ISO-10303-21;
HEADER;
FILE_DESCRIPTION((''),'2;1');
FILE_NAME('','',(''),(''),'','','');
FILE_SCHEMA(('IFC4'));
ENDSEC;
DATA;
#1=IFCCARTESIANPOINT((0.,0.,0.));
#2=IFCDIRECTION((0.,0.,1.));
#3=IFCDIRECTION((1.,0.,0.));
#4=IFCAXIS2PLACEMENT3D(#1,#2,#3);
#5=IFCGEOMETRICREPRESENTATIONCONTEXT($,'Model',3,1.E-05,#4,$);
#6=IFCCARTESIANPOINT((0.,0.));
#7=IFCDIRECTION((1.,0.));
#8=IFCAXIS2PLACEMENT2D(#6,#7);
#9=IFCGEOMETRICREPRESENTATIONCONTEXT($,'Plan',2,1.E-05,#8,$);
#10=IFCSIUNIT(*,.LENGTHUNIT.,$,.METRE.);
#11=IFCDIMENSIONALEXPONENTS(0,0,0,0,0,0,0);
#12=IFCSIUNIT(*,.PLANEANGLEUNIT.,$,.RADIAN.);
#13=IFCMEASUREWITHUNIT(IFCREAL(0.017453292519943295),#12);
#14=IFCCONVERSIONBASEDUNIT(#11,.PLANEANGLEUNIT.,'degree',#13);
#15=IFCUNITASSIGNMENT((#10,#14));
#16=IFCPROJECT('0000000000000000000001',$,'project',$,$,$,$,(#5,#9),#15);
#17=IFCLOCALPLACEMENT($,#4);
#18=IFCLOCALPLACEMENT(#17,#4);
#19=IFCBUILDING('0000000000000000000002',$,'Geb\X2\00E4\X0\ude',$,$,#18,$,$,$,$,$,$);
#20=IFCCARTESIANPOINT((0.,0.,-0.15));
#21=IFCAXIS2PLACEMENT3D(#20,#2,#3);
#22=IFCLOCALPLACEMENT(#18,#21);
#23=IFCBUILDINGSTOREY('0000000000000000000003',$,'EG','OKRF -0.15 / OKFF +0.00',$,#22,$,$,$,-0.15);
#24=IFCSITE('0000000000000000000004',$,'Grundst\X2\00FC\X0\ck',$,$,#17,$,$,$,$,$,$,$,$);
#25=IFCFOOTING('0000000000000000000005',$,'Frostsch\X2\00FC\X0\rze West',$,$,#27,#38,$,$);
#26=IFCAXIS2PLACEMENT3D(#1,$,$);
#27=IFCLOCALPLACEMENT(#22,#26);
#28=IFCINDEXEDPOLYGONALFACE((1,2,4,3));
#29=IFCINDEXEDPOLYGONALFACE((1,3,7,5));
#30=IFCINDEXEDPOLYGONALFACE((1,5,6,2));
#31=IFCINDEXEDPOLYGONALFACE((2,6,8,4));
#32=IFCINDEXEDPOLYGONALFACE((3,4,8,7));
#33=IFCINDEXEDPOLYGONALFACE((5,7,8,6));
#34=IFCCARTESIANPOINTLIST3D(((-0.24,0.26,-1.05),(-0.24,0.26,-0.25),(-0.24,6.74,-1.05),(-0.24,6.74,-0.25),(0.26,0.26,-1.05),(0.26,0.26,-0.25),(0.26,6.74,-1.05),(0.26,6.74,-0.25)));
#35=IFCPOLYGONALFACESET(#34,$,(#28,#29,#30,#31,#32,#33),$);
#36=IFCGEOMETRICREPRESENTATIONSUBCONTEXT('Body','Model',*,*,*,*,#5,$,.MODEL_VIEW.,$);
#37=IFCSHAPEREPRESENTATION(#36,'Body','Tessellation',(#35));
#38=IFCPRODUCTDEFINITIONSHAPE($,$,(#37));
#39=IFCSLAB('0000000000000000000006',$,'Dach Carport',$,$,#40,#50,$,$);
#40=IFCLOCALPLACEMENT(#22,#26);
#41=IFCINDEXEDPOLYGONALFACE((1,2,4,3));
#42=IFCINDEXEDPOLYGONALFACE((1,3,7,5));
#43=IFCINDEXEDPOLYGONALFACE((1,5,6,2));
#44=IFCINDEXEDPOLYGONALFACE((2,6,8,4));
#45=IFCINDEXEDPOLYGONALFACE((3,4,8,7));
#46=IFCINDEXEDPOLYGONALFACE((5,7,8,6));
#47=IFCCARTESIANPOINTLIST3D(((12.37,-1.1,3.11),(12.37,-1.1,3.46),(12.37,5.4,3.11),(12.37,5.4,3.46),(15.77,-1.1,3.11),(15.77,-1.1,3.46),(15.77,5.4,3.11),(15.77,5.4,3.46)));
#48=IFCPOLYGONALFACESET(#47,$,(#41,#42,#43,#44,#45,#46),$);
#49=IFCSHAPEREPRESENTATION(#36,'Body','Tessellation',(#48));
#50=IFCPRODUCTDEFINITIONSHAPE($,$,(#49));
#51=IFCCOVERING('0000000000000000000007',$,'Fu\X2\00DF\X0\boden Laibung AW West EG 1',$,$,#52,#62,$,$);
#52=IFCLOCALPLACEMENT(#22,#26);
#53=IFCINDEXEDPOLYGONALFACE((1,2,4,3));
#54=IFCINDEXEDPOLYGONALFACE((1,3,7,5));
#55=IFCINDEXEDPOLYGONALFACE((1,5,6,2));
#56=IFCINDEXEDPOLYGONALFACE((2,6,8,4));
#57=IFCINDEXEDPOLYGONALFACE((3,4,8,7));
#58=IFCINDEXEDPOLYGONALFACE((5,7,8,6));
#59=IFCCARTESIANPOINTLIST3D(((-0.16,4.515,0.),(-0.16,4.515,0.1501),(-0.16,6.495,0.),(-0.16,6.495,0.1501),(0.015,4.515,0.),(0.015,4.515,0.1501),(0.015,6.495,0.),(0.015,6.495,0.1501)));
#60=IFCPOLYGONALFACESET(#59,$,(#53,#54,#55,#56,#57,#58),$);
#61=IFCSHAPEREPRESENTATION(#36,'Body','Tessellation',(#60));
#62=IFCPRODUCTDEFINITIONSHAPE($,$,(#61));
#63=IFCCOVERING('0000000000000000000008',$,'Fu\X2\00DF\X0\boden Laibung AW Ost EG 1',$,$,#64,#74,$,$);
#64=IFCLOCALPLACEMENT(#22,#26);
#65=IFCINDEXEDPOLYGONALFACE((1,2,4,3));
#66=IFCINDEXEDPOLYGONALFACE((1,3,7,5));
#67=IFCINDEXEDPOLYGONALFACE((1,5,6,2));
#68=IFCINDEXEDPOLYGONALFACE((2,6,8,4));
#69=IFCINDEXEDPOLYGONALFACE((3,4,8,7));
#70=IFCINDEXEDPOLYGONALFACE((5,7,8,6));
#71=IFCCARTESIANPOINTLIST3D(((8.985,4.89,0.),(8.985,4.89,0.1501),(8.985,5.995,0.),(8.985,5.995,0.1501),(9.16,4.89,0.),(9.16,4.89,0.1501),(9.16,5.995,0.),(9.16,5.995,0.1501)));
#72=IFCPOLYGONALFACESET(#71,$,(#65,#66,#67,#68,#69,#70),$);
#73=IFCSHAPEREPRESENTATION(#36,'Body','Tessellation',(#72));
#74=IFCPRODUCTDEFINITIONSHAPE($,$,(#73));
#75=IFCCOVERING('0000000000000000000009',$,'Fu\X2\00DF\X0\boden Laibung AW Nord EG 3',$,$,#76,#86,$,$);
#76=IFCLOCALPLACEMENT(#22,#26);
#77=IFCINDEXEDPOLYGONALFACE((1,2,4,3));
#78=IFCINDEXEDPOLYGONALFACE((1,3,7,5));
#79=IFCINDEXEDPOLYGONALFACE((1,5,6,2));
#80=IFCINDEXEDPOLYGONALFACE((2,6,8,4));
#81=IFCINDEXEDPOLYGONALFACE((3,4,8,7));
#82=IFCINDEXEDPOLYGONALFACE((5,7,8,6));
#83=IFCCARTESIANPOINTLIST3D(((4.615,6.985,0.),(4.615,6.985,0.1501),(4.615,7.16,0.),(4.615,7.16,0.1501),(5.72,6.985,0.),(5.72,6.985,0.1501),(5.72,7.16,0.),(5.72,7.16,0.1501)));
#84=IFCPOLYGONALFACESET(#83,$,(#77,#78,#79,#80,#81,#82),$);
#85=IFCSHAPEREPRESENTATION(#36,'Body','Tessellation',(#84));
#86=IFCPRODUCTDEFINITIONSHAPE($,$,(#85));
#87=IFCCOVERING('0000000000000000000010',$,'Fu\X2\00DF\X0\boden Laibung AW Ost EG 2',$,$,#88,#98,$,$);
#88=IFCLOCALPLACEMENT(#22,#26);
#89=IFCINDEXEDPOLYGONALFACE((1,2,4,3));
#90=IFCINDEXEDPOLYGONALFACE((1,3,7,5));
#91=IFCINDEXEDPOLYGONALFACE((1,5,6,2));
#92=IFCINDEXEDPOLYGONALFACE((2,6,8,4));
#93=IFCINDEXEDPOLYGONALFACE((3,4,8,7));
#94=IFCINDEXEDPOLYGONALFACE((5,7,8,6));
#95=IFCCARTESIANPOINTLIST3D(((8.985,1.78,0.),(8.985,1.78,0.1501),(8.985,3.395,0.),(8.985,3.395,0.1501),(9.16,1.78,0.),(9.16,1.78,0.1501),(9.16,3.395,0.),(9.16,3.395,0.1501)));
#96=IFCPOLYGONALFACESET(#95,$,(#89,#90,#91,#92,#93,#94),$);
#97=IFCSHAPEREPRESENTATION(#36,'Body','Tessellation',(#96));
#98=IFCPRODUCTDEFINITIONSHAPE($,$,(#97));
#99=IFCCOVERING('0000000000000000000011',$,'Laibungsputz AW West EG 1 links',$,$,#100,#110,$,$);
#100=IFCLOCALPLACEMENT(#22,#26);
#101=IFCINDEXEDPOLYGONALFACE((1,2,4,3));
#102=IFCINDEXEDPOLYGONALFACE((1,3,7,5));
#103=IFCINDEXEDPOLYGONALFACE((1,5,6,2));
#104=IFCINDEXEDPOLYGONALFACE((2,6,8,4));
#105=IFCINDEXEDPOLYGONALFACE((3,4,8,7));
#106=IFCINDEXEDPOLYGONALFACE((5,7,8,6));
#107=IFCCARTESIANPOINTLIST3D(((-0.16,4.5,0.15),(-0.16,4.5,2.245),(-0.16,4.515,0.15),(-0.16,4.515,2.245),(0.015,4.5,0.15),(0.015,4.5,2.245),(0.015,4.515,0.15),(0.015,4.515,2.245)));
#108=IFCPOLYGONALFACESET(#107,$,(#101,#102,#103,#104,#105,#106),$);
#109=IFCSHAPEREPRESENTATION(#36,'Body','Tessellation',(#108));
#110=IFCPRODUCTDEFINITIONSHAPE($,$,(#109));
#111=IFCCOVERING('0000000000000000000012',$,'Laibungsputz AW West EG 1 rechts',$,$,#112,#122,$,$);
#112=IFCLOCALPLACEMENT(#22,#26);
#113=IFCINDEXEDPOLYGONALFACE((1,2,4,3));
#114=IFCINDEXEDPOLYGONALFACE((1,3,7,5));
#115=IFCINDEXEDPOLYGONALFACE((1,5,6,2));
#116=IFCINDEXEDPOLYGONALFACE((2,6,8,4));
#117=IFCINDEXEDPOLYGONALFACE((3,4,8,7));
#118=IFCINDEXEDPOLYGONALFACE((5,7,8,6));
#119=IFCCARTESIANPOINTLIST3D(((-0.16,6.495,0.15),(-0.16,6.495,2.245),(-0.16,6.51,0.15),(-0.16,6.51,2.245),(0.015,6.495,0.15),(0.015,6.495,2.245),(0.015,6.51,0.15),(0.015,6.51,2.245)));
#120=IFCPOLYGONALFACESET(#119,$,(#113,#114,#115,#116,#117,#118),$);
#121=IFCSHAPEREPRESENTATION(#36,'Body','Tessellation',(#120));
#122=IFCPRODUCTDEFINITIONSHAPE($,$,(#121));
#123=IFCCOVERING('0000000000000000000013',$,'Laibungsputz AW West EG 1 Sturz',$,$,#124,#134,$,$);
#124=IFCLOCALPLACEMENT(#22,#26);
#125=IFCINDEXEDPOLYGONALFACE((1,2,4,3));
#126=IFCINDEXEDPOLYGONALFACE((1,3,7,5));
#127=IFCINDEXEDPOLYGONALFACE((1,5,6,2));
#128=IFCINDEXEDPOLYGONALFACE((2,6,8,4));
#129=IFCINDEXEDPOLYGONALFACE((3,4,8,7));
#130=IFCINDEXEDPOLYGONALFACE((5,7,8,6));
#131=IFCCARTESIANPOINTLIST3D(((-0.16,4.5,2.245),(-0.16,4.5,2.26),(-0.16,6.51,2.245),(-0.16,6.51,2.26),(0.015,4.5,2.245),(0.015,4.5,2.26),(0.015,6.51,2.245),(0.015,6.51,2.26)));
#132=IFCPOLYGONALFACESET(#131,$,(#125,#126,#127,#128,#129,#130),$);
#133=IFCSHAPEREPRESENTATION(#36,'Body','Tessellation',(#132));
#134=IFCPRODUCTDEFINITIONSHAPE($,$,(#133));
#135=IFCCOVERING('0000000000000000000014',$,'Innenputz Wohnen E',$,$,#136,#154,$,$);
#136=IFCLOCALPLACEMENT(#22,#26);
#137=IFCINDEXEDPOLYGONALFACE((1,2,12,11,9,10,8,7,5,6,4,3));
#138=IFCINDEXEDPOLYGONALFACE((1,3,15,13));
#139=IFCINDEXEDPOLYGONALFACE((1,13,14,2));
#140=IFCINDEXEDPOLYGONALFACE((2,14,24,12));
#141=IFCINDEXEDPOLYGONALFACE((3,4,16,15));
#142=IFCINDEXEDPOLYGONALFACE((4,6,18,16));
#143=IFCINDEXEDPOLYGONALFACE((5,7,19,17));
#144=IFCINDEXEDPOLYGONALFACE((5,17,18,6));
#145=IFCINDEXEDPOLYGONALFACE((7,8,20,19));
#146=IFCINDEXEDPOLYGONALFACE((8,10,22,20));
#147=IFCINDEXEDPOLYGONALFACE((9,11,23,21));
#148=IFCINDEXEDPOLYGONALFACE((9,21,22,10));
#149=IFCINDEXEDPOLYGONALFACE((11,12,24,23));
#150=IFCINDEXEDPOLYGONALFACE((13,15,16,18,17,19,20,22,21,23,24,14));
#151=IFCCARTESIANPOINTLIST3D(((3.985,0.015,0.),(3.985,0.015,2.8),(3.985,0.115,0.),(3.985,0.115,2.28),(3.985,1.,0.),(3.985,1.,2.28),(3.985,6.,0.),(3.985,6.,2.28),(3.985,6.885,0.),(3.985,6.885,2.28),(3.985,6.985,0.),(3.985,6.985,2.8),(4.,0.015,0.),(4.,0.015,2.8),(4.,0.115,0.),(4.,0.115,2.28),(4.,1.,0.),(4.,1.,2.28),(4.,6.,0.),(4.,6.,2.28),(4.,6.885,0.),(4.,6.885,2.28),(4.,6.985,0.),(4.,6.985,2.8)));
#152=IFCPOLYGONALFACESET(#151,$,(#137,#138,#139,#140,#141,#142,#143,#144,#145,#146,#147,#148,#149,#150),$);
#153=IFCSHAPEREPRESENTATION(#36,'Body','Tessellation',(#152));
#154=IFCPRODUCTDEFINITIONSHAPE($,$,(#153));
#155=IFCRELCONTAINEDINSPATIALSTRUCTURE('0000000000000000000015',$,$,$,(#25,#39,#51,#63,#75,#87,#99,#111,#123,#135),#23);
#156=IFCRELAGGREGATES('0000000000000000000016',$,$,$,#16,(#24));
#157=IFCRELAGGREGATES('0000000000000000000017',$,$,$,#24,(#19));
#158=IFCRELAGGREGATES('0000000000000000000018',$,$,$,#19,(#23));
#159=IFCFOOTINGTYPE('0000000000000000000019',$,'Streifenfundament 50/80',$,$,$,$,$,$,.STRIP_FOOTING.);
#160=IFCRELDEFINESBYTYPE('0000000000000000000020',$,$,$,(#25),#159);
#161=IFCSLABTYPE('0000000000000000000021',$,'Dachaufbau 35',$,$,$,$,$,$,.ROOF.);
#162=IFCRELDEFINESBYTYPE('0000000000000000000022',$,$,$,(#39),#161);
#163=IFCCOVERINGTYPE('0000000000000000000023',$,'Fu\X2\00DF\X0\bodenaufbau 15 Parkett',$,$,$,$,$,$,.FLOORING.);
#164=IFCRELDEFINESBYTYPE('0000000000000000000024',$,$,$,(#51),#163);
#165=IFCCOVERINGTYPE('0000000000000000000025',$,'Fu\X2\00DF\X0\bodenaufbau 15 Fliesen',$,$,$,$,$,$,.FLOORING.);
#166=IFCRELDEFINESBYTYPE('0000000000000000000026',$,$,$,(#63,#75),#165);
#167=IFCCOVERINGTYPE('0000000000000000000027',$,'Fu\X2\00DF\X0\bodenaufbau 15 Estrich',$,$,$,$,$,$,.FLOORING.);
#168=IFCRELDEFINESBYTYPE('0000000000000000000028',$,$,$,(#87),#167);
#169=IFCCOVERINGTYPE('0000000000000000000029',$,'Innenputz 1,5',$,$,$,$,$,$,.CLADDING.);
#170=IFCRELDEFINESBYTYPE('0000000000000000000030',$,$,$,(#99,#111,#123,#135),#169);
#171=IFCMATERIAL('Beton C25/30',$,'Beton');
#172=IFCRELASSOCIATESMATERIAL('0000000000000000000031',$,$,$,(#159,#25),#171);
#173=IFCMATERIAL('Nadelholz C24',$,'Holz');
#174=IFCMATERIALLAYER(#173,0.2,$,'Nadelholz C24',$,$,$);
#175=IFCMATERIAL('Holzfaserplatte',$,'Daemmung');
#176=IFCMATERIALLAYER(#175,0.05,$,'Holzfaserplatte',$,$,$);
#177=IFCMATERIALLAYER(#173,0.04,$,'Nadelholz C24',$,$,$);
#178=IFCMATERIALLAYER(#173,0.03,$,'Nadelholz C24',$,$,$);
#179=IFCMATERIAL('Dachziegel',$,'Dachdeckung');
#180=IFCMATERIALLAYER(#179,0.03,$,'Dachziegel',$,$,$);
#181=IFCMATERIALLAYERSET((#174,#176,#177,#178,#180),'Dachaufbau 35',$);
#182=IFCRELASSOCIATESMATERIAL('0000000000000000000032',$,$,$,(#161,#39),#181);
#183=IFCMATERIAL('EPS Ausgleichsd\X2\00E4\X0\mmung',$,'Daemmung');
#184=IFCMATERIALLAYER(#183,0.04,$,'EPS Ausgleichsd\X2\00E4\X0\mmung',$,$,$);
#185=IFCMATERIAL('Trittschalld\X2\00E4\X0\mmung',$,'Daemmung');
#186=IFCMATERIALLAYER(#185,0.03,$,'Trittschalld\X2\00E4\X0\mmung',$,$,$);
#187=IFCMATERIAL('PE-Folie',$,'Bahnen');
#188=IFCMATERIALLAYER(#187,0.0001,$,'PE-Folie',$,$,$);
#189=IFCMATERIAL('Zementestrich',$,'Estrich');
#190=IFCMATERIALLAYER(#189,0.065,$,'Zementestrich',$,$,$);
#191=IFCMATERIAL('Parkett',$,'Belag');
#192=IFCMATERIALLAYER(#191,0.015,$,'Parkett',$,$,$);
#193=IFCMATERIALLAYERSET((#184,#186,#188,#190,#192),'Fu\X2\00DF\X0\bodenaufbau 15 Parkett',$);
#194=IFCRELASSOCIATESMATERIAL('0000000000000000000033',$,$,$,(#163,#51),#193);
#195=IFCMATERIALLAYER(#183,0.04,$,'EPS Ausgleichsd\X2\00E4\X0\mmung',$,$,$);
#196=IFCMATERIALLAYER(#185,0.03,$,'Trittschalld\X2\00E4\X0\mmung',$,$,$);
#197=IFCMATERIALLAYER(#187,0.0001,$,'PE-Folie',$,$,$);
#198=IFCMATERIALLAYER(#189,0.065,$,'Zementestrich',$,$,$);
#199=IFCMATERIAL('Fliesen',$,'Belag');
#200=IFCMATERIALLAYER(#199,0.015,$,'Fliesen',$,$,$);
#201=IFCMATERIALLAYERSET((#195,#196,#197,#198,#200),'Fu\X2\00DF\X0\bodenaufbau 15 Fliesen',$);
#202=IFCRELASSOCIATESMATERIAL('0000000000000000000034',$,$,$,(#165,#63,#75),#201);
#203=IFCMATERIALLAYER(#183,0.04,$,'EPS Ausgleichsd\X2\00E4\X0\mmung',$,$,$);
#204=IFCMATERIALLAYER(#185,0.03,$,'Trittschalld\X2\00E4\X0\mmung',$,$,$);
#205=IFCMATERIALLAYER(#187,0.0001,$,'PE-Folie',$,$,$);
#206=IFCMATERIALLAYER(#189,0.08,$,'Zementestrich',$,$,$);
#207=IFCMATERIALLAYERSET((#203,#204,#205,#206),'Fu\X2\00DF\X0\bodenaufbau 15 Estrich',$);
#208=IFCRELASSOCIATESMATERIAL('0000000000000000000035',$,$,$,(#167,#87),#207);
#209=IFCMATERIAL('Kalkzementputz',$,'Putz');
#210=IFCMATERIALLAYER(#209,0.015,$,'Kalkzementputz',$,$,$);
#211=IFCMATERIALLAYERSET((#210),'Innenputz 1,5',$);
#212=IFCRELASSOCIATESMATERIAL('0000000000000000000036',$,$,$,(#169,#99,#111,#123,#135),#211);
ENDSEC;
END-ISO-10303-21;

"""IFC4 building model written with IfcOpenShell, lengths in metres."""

from ifc_helpers import new_model, entity, si_unit, converted_unit, frame, origin_with_axes, origin_2d_with_axis, place, context, subcontext, project, spatial, polyline, indexed_curve, rectangle, outline, extrude, material, layer, layer_set, layer_usage, material_profile, profile_set, profile_usage, type_object, element, save


model = new_model("IFC4")

# Units and contexts
model_context = context("Model", 3, precision=1e-05, world=origin_with_axes())
plan_context = context("Plan", 2, precision=1e-05, world=origin_2d_with_axis())
body_context = subcontext(model_context, "Body", "Model", "MODEL_VIEW")
ifc_project = project(units=[si_unit("LENGTHUNIT", "METRE"), converted_unit("PLANEANGLEUNIT", "degree", entity("IfcReal", 0.017453292519943295), si_unit("PLANEANGLEUNIT", "RADIAN"), dimensions=[0, 0, 0, 0, 0, 0, 0])], contexts=[model_context, plan_context])

# Site, building, storey
site_placement = place(None, origin_with_axes())
site = spatial("IfcSite", under=ifc_project, at=site_placement, Name="Grundstück")
building_placement = place(site_placement, origin_with_axes())
building = spatial("IfcBuilding", under=site, at=building_placement, Name="Gebäude")
storey_placement = place(building_placement, frame((0.0, 0.0, -0.15), z_axis=(0.0, 0.0, 1.0), x_axis=(1.0, 0.0, 0.0)))
storey = spatial("IfcBuildingStorey", under=building, at=storey_placement, Name="EG", Description="OKRF -0.15 / OKFF +0.00", Elevation=-0.15)

# Footing
ifc_material_1 = material(Name="Beton C25/30", Category="Beton")
ifc_material_profile = material_profile(ifc_material_1, rectangle(XDim=0.5, YDim=0.8))
ifc_profile_set = profile_set([ifc_material_profile], Name="Streifenfundament 50/80")
ifc_profile_usage = profile_usage(ifc_profile_set)
footing_type = type_object("IfcFootingType", Name="Streifenfundament 50/80", PredefinedType="STRIP_FOOTING", material=ifc_profile_set)
footing_placement = place(storey_placement, frame((0.01, 0.26, -0.65), z_axis=(0.0, 1.0, 0.0), x_axis=(-1.0, 0.0, 0.0)))
element("IfcFooting", 1, at=footing_placement, inside=storey, type_object=footing_type, material=ifc_profile_usage, Name="Frostschürze West", context=body_context, shape_type="SweptSolid", body=[
    extrude(rectangle(XDim=0.5, YDim=0.8), origin_with_axes(), (0.0, 0.0, 1.0), 6.48),
])

# Slab
ifc_material_2 = material(Name="Nadelholz C24", Category="Holz")
ifc_layer_1 = layer(ifc_material_2, 0.2, Name="Nadelholz C24")
ifc_material_3 = material(Name="Holzfaserplatte", Category="Daemmung")
ifc_layer_2 = layer(ifc_material_3, 0.05, Name="Holzfaserplatte")
ifc_layer_3 = layer(ifc_material_2, 0.04, Name="Nadelholz C24")
ifc_layer_4 = layer(ifc_material_2, 0.03, Name="Nadelholz C24")
ifc_material_4 = material(Name="Dachziegel", Category="Dachdeckung")
ifc_layer_5 = layer(ifc_material_4, 0.03, Name="Dachziegel")
ifc_layer_set_1 = layer_set([ifc_layer_1, ifc_layer_2, ifc_layer_3, ifc_layer_4, ifc_layer_5], Name="Dachaufbau 35")
ifc_layer_usage_1 = layer_usage(ifc_layer_set_1, "AXIS3", "POSITIVE", 0.0)
slab_type = type_object("IfcSlabType", Name="Dachaufbau 35", PredefinedType="ROOF", material=ifc_layer_set_1)
slab_placement = place(storey_placement, frame((0.0, 0.0, 3.11), z_axis=(0.0, 0.0, 1.0), x_axis=(1.0, 0.0, 0.0)))
element("IfcSlab", 2, at=slab_placement, inside=storey, type_object=slab_type, material=ifc_layer_usage_1, Name="Dach Carport", context=body_context, shape_type="SweptSolid", body=[
    extrude(outline(indexed_curve([(12.37, -1.1), (15.77, -1.1), (15.77, 5.4), (12.37, 5.4)])), None, (0.0, 0.0, 1.0), 0.35),
])

# Coverings
ifc_material_5 = material(Name="EPS Ausgleichsdämmung", Category="Daemmung")
ifc_layer_6 = layer(ifc_material_5, 0.04, Name="EPS Ausgleichsdämmung")
ifc_material_6 = material(Name="Trittschalldämmung", Category="Daemmung")
ifc_layer_7 = layer(ifc_material_6, 0.03, Name="Trittschalldämmung")
ifc_material_7 = material(Name="PE-Folie", Category="Bahnen")
ifc_layer_8 = layer(ifc_material_7, 0.0001, Name="PE-Folie")
ifc_material_8 = material(Name="Zementestrich", Category="Estrich")
ifc_layer_9 = layer(ifc_material_8, 0.065, Name="Zementestrich")
ifc_material_9 = material(Name="Parkett", Category="Belag")
ifc_layer_10 = layer(ifc_material_9, 0.015, Name="Parkett")
ifc_layer_set_2 = layer_set([ifc_layer_6, ifc_layer_7, ifc_layer_8, ifc_layer_9, ifc_layer_10], Name="Fußbodenaufbau 15 Parkett")
ifc_layer_usage_2 = layer_usage(ifc_layer_set_2, "AXIS3", "POSITIVE", 0.0)
covering_type_1 = type_object("IfcCoveringType", Name="Fußbodenaufbau 15 Parkett", PredefinedType="FLOORING", material=ifc_layer_set_2)
covering_1_placement = place(storey_placement, origin_with_axes())
element("IfcCovering", 3, at=covering_1_placement, inside=storey, type_object=covering_type_1, material=ifc_layer_usage_2, Name="Fußboden Laibung AW West EG 1", context=body_context, shape_type="SweptSolid", body=[
    extrude(outline(indexed_curve([(-0.16, 4.515), (0.015, 4.515), (0.015, 6.495), (-0.16, 6.495)])), None, (0.0, 0.0, 1.0), 0.1501),
])
ifc_layer_11 = layer(ifc_material_5, 0.04, Name="EPS Ausgleichsdämmung")
ifc_layer_12 = layer(ifc_material_6, 0.03, Name="Trittschalldämmung")
ifc_layer_13 = layer(ifc_material_7, 0.0001, Name="PE-Folie")
ifc_layer_14 = layer(ifc_material_8, 0.065, Name="Zementestrich")
ifc_material_10 = material(Name="Fliesen", Category="Belag")
ifc_layer_15 = layer(ifc_material_10, 0.015, Name="Fliesen")
ifc_layer_set_3 = layer_set([ifc_layer_11, ifc_layer_12, ifc_layer_13, ifc_layer_14, ifc_layer_15], Name="Fußbodenaufbau 15 Fliesen")
ifc_layer_usage_3 = layer_usage(ifc_layer_set_3, "AXIS3", "POSITIVE", 0.0)
covering_type_2 = type_object("IfcCoveringType", Name="Fußbodenaufbau 15 Fliesen", PredefinedType="FLOORING", material=ifc_layer_set_3)
covering_2_placement = place(storey_placement, origin_with_axes())
element("IfcCovering", 4, at=covering_2_placement, inside=storey, type_object=covering_type_2, material=ifc_layer_usage_3, Name="Fußboden Laibung AW Ost EG 1", context=body_context, shape_type="SweptSolid", body=[
    extrude(outline(indexed_curve([(8.985, 4.89), (9.16, 4.89), (9.16, 5.995), (8.985, 5.995)])), None, (0.0, 0.0, 1.0), 0.1501),
])
ifc_layer_usage_4 = layer_usage(ifc_layer_set_3, "AXIS3", "POSITIVE", 0.0)
covering_3_placement = place(storey_placement, origin_with_axes())
element("IfcCovering", 5, at=covering_3_placement, inside=storey, type_object=covering_type_2, material=ifc_layer_usage_4, Name="Fußboden Laibung AW Nord EG 3", context=body_context, shape_type="SweptSolid", body=[
    extrude(outline(indexed_curve([(4.615, 6.985), (5.72, 6.985), (5.72, 7.16), (4.615, 7.16)])), None, (0.0, 0.0, 1.0), 0.1501),
])
ifc_layer_16 = layer(ifc_material_5, 0.04, Name="EPS Ausgleichsdämmung")
ifc_layer_17 = layer(ifc_material_6, 0.03, Name="Trittschalldämmung")
ifc_layer_18 = layer(ifc_material_7, 0.0001, Name="PE-Folie")
ifc_layer_19 = layer(ifc_material_8, 0.08, Name="Zementestrich")
ifc_layer_set_4 = layer_set([ifc_layer_16, ifc_layer_17, ifc_layer_18, ifc_layer_19], Name="Fußbodenaufbau 15 Estrich")
ifc_layer_usage_5 = layer_usage(ifc_layer_set_4, "AXIS3", "POSITIVE", 0.0)
covering_type_3 = type_object("IfcCoveringType", Name="Fußbodenaufbau 15 Estrich", PredefinedType="FLOORING", material=ifc_layer_set_4)
covering_4_placement = place(storey_placement, origin_with_axes())
element("IfcCovering", 6, at=covering_4_placement, inside=storey, type_object=covering_type_3, material=ifc_layer_usage_5, Name="Fußboden Laibung AW Ost EG 2", context=body_context, shape_type="SweptSolid", body=[
    extrude(outline(indexed_curve([(8.985, 1.78), (9.16, 1.78), (9.16, 3.395), (8.985, 3.395)])), None, (0.0, 0.0, 1.0), 0.1501),
])
ifc_material_11 = material(Name="Kalkzementputz", Category="Putz")
ifc_layer_20 = layer(ifc_material_11, 0.015, Name="Kalkzementputz")
ifc_layer_set_5 = layer_set([ifc_layer_20], Name="Innenputz 1,5")
ifc_layer_usage_6 = layer_usage(ifc_layer_set_5, "AXIS1", "POSITIVE", 4.5)
covering_type_4 = type_object("IfcCoveringType", Name="Innenputz 1,5", PredefinedType="CLADDING", material=ifc_layer_set_5)
covering_5_placement = place(storey_placement, frame((0.0, 0.0, 0.0), z_axis=(0.0, 0.0, 1.0), x_axis=(0.0, 1.0, 0.0)))
element("IfcCovering", 7, at=covering_5_placement, inside=storey, type_object=covering_type_4, material=ifc_layer_usage_6, Name="Laibungsputz AW West EG 1 links", context=body_context, shape_type="SweptSolid", body=[
    extrude(outline(polyline([(-0.015, 0.15), (0.16, 0.15), (0.16, 2.245), (-0.015, 2.245), (-0.015, 0.15)])), frame((4.5, 0.0, 0.0), z_axis=(1.0, 0.0, 0.0), x_axis=(0.0, 1.0, 0.0)), (0.0, 0.0, 1.0), 0.015),
])
ifc_layer_usage_7 = layer_usage(ifc_layer_set_5, "AXIS1", "POSITIVE", 6.495)
covering_6_placement = place(storey_placement, frame((0.0, 0.0, 0.0), z_axis=(0.0, 0.0, 1.0), x_axis=(0.0, 1.0, 0.0)))
element("IfcCovering", 8, at=covering_6_placement, inside=storey, type_object=covering_type_4, material=ifc_layer_usage_7, Name="Laibungsputz AW West EG 1 rechts", context=body_context, shape_type="SweptSolid", body=[
    extrude(outline(polyline([(-0.015, 0.15), (0.16, 0.15), (0.16, 2.245), (-0.015, 2.245), (-0.015, 0.15)])), frame((6.495, 0.0, 0.0), z_axis=(1.0, 0.0, 0.0), x_axis=(0.0, 1.0, 0.0)), (0.0, 0.0, 1.0), 0.015),
])
ifc_layer_usage_8 = layer_usage(ifc_layer_set_5, "AXIS3", "POSITIVE", 2.245)
covering_7_placement = place(storey_placement, frame((0.0, 0.0, 0.0), z_axis=(0.0, 0.0, 1.0), x_axis=(0.0, 1.0, 0.0)))
element("IfcCovering", 9, at=covering_7_placement, inside=storey, type_object=covering_type_4, material=ifc_layer_usage_8, Name="Laibungsputz AW West EG 1 Sturz", context=body_context, shape_type="SweptSolid", body=[
    extrude(outline(polyline([(-0.015, 2.245), (0.16, 2.245), (0.16, 2.26), (-0.015, 2.26), (-0.015, 2.245)])), frame((4.5, 0.0, 0.0), z_axis=(1.0, 0.0, 0.0), x_axis=(0.0, 1.0, 0.0)), (0.0, 0.0, 1.0), 2.01),
])

# Covering, openings
ifc_layer_usage_9 = layer_usage(ifc_layer_set_5, "AXIS2", "POSITIVE", 0.0)
covering_8_placement = place(storey_placement, frame((4.0, 0.015, 0.0), z_axis=(0.0, 0.0, 1.0), x_axis=(0.0, 1.0, 0.0)))
covering_8 = element("IfcCovering", 10, at=covering_8_placement, inside=storey, type_object=covering_type_4, material=ifc_layer_usage_9, Name="Innenputz Wohnen E", context=body_context, shape_type="SweptSolid", body=[
    extrude(outline(indexed_curve([(0.0, 0.0), (0.0, 0.015), (6.97, 0.015), (6.97, 0.0), (0.0, 0.0)], self_intersect=False)), origin_with_axes(), (0.0, 0.0, 1.0), 2.8),
])
opening_1_placement = place(covering_8_placement, frame((5.985, -0.05, 0.0), z_axis=(0.0, 0.0, 1.0), x_axis=(1.0, 0.0, 0.0)))
element("IfcOpeningElement", 11, at=opening_1_placement, cuts=covering_8, context=body_context, shape_type="SweptSolid", body=[
    extrude(outline(indexed_curve([(0.0, 0.0), (0.0, 0.115), (0.885, 0.115), (0.885, 0.0), (0.0, 0.0)], self_intersect=False)), origin_with_axes(), (0.0, 0.0, 1.0), 2.28),
])
opening_2_placement = place(covering_8_placement, frame((0.1, -0.05, 0.0), z_axis=(0.0, 0.0, 1.0), x_axis=(1.0, 0.0, 0.0)))
element("IfcOpeningElement", 12, at=opening_2_placement, cuts=covering_8, context=body_context, shape_type="SweptSolid", body=[
    extrude(outline(indexed_curve([(0.0, 0.0), (0.0, 0.115), (0.885, 0.115), (0.885, 0.0), (0.0, 0.0)], self_intersect=False)), origin_with_axes(), (0.0, 0.0, 1.0), 2.28),
])

save(model, "model.ifc")
